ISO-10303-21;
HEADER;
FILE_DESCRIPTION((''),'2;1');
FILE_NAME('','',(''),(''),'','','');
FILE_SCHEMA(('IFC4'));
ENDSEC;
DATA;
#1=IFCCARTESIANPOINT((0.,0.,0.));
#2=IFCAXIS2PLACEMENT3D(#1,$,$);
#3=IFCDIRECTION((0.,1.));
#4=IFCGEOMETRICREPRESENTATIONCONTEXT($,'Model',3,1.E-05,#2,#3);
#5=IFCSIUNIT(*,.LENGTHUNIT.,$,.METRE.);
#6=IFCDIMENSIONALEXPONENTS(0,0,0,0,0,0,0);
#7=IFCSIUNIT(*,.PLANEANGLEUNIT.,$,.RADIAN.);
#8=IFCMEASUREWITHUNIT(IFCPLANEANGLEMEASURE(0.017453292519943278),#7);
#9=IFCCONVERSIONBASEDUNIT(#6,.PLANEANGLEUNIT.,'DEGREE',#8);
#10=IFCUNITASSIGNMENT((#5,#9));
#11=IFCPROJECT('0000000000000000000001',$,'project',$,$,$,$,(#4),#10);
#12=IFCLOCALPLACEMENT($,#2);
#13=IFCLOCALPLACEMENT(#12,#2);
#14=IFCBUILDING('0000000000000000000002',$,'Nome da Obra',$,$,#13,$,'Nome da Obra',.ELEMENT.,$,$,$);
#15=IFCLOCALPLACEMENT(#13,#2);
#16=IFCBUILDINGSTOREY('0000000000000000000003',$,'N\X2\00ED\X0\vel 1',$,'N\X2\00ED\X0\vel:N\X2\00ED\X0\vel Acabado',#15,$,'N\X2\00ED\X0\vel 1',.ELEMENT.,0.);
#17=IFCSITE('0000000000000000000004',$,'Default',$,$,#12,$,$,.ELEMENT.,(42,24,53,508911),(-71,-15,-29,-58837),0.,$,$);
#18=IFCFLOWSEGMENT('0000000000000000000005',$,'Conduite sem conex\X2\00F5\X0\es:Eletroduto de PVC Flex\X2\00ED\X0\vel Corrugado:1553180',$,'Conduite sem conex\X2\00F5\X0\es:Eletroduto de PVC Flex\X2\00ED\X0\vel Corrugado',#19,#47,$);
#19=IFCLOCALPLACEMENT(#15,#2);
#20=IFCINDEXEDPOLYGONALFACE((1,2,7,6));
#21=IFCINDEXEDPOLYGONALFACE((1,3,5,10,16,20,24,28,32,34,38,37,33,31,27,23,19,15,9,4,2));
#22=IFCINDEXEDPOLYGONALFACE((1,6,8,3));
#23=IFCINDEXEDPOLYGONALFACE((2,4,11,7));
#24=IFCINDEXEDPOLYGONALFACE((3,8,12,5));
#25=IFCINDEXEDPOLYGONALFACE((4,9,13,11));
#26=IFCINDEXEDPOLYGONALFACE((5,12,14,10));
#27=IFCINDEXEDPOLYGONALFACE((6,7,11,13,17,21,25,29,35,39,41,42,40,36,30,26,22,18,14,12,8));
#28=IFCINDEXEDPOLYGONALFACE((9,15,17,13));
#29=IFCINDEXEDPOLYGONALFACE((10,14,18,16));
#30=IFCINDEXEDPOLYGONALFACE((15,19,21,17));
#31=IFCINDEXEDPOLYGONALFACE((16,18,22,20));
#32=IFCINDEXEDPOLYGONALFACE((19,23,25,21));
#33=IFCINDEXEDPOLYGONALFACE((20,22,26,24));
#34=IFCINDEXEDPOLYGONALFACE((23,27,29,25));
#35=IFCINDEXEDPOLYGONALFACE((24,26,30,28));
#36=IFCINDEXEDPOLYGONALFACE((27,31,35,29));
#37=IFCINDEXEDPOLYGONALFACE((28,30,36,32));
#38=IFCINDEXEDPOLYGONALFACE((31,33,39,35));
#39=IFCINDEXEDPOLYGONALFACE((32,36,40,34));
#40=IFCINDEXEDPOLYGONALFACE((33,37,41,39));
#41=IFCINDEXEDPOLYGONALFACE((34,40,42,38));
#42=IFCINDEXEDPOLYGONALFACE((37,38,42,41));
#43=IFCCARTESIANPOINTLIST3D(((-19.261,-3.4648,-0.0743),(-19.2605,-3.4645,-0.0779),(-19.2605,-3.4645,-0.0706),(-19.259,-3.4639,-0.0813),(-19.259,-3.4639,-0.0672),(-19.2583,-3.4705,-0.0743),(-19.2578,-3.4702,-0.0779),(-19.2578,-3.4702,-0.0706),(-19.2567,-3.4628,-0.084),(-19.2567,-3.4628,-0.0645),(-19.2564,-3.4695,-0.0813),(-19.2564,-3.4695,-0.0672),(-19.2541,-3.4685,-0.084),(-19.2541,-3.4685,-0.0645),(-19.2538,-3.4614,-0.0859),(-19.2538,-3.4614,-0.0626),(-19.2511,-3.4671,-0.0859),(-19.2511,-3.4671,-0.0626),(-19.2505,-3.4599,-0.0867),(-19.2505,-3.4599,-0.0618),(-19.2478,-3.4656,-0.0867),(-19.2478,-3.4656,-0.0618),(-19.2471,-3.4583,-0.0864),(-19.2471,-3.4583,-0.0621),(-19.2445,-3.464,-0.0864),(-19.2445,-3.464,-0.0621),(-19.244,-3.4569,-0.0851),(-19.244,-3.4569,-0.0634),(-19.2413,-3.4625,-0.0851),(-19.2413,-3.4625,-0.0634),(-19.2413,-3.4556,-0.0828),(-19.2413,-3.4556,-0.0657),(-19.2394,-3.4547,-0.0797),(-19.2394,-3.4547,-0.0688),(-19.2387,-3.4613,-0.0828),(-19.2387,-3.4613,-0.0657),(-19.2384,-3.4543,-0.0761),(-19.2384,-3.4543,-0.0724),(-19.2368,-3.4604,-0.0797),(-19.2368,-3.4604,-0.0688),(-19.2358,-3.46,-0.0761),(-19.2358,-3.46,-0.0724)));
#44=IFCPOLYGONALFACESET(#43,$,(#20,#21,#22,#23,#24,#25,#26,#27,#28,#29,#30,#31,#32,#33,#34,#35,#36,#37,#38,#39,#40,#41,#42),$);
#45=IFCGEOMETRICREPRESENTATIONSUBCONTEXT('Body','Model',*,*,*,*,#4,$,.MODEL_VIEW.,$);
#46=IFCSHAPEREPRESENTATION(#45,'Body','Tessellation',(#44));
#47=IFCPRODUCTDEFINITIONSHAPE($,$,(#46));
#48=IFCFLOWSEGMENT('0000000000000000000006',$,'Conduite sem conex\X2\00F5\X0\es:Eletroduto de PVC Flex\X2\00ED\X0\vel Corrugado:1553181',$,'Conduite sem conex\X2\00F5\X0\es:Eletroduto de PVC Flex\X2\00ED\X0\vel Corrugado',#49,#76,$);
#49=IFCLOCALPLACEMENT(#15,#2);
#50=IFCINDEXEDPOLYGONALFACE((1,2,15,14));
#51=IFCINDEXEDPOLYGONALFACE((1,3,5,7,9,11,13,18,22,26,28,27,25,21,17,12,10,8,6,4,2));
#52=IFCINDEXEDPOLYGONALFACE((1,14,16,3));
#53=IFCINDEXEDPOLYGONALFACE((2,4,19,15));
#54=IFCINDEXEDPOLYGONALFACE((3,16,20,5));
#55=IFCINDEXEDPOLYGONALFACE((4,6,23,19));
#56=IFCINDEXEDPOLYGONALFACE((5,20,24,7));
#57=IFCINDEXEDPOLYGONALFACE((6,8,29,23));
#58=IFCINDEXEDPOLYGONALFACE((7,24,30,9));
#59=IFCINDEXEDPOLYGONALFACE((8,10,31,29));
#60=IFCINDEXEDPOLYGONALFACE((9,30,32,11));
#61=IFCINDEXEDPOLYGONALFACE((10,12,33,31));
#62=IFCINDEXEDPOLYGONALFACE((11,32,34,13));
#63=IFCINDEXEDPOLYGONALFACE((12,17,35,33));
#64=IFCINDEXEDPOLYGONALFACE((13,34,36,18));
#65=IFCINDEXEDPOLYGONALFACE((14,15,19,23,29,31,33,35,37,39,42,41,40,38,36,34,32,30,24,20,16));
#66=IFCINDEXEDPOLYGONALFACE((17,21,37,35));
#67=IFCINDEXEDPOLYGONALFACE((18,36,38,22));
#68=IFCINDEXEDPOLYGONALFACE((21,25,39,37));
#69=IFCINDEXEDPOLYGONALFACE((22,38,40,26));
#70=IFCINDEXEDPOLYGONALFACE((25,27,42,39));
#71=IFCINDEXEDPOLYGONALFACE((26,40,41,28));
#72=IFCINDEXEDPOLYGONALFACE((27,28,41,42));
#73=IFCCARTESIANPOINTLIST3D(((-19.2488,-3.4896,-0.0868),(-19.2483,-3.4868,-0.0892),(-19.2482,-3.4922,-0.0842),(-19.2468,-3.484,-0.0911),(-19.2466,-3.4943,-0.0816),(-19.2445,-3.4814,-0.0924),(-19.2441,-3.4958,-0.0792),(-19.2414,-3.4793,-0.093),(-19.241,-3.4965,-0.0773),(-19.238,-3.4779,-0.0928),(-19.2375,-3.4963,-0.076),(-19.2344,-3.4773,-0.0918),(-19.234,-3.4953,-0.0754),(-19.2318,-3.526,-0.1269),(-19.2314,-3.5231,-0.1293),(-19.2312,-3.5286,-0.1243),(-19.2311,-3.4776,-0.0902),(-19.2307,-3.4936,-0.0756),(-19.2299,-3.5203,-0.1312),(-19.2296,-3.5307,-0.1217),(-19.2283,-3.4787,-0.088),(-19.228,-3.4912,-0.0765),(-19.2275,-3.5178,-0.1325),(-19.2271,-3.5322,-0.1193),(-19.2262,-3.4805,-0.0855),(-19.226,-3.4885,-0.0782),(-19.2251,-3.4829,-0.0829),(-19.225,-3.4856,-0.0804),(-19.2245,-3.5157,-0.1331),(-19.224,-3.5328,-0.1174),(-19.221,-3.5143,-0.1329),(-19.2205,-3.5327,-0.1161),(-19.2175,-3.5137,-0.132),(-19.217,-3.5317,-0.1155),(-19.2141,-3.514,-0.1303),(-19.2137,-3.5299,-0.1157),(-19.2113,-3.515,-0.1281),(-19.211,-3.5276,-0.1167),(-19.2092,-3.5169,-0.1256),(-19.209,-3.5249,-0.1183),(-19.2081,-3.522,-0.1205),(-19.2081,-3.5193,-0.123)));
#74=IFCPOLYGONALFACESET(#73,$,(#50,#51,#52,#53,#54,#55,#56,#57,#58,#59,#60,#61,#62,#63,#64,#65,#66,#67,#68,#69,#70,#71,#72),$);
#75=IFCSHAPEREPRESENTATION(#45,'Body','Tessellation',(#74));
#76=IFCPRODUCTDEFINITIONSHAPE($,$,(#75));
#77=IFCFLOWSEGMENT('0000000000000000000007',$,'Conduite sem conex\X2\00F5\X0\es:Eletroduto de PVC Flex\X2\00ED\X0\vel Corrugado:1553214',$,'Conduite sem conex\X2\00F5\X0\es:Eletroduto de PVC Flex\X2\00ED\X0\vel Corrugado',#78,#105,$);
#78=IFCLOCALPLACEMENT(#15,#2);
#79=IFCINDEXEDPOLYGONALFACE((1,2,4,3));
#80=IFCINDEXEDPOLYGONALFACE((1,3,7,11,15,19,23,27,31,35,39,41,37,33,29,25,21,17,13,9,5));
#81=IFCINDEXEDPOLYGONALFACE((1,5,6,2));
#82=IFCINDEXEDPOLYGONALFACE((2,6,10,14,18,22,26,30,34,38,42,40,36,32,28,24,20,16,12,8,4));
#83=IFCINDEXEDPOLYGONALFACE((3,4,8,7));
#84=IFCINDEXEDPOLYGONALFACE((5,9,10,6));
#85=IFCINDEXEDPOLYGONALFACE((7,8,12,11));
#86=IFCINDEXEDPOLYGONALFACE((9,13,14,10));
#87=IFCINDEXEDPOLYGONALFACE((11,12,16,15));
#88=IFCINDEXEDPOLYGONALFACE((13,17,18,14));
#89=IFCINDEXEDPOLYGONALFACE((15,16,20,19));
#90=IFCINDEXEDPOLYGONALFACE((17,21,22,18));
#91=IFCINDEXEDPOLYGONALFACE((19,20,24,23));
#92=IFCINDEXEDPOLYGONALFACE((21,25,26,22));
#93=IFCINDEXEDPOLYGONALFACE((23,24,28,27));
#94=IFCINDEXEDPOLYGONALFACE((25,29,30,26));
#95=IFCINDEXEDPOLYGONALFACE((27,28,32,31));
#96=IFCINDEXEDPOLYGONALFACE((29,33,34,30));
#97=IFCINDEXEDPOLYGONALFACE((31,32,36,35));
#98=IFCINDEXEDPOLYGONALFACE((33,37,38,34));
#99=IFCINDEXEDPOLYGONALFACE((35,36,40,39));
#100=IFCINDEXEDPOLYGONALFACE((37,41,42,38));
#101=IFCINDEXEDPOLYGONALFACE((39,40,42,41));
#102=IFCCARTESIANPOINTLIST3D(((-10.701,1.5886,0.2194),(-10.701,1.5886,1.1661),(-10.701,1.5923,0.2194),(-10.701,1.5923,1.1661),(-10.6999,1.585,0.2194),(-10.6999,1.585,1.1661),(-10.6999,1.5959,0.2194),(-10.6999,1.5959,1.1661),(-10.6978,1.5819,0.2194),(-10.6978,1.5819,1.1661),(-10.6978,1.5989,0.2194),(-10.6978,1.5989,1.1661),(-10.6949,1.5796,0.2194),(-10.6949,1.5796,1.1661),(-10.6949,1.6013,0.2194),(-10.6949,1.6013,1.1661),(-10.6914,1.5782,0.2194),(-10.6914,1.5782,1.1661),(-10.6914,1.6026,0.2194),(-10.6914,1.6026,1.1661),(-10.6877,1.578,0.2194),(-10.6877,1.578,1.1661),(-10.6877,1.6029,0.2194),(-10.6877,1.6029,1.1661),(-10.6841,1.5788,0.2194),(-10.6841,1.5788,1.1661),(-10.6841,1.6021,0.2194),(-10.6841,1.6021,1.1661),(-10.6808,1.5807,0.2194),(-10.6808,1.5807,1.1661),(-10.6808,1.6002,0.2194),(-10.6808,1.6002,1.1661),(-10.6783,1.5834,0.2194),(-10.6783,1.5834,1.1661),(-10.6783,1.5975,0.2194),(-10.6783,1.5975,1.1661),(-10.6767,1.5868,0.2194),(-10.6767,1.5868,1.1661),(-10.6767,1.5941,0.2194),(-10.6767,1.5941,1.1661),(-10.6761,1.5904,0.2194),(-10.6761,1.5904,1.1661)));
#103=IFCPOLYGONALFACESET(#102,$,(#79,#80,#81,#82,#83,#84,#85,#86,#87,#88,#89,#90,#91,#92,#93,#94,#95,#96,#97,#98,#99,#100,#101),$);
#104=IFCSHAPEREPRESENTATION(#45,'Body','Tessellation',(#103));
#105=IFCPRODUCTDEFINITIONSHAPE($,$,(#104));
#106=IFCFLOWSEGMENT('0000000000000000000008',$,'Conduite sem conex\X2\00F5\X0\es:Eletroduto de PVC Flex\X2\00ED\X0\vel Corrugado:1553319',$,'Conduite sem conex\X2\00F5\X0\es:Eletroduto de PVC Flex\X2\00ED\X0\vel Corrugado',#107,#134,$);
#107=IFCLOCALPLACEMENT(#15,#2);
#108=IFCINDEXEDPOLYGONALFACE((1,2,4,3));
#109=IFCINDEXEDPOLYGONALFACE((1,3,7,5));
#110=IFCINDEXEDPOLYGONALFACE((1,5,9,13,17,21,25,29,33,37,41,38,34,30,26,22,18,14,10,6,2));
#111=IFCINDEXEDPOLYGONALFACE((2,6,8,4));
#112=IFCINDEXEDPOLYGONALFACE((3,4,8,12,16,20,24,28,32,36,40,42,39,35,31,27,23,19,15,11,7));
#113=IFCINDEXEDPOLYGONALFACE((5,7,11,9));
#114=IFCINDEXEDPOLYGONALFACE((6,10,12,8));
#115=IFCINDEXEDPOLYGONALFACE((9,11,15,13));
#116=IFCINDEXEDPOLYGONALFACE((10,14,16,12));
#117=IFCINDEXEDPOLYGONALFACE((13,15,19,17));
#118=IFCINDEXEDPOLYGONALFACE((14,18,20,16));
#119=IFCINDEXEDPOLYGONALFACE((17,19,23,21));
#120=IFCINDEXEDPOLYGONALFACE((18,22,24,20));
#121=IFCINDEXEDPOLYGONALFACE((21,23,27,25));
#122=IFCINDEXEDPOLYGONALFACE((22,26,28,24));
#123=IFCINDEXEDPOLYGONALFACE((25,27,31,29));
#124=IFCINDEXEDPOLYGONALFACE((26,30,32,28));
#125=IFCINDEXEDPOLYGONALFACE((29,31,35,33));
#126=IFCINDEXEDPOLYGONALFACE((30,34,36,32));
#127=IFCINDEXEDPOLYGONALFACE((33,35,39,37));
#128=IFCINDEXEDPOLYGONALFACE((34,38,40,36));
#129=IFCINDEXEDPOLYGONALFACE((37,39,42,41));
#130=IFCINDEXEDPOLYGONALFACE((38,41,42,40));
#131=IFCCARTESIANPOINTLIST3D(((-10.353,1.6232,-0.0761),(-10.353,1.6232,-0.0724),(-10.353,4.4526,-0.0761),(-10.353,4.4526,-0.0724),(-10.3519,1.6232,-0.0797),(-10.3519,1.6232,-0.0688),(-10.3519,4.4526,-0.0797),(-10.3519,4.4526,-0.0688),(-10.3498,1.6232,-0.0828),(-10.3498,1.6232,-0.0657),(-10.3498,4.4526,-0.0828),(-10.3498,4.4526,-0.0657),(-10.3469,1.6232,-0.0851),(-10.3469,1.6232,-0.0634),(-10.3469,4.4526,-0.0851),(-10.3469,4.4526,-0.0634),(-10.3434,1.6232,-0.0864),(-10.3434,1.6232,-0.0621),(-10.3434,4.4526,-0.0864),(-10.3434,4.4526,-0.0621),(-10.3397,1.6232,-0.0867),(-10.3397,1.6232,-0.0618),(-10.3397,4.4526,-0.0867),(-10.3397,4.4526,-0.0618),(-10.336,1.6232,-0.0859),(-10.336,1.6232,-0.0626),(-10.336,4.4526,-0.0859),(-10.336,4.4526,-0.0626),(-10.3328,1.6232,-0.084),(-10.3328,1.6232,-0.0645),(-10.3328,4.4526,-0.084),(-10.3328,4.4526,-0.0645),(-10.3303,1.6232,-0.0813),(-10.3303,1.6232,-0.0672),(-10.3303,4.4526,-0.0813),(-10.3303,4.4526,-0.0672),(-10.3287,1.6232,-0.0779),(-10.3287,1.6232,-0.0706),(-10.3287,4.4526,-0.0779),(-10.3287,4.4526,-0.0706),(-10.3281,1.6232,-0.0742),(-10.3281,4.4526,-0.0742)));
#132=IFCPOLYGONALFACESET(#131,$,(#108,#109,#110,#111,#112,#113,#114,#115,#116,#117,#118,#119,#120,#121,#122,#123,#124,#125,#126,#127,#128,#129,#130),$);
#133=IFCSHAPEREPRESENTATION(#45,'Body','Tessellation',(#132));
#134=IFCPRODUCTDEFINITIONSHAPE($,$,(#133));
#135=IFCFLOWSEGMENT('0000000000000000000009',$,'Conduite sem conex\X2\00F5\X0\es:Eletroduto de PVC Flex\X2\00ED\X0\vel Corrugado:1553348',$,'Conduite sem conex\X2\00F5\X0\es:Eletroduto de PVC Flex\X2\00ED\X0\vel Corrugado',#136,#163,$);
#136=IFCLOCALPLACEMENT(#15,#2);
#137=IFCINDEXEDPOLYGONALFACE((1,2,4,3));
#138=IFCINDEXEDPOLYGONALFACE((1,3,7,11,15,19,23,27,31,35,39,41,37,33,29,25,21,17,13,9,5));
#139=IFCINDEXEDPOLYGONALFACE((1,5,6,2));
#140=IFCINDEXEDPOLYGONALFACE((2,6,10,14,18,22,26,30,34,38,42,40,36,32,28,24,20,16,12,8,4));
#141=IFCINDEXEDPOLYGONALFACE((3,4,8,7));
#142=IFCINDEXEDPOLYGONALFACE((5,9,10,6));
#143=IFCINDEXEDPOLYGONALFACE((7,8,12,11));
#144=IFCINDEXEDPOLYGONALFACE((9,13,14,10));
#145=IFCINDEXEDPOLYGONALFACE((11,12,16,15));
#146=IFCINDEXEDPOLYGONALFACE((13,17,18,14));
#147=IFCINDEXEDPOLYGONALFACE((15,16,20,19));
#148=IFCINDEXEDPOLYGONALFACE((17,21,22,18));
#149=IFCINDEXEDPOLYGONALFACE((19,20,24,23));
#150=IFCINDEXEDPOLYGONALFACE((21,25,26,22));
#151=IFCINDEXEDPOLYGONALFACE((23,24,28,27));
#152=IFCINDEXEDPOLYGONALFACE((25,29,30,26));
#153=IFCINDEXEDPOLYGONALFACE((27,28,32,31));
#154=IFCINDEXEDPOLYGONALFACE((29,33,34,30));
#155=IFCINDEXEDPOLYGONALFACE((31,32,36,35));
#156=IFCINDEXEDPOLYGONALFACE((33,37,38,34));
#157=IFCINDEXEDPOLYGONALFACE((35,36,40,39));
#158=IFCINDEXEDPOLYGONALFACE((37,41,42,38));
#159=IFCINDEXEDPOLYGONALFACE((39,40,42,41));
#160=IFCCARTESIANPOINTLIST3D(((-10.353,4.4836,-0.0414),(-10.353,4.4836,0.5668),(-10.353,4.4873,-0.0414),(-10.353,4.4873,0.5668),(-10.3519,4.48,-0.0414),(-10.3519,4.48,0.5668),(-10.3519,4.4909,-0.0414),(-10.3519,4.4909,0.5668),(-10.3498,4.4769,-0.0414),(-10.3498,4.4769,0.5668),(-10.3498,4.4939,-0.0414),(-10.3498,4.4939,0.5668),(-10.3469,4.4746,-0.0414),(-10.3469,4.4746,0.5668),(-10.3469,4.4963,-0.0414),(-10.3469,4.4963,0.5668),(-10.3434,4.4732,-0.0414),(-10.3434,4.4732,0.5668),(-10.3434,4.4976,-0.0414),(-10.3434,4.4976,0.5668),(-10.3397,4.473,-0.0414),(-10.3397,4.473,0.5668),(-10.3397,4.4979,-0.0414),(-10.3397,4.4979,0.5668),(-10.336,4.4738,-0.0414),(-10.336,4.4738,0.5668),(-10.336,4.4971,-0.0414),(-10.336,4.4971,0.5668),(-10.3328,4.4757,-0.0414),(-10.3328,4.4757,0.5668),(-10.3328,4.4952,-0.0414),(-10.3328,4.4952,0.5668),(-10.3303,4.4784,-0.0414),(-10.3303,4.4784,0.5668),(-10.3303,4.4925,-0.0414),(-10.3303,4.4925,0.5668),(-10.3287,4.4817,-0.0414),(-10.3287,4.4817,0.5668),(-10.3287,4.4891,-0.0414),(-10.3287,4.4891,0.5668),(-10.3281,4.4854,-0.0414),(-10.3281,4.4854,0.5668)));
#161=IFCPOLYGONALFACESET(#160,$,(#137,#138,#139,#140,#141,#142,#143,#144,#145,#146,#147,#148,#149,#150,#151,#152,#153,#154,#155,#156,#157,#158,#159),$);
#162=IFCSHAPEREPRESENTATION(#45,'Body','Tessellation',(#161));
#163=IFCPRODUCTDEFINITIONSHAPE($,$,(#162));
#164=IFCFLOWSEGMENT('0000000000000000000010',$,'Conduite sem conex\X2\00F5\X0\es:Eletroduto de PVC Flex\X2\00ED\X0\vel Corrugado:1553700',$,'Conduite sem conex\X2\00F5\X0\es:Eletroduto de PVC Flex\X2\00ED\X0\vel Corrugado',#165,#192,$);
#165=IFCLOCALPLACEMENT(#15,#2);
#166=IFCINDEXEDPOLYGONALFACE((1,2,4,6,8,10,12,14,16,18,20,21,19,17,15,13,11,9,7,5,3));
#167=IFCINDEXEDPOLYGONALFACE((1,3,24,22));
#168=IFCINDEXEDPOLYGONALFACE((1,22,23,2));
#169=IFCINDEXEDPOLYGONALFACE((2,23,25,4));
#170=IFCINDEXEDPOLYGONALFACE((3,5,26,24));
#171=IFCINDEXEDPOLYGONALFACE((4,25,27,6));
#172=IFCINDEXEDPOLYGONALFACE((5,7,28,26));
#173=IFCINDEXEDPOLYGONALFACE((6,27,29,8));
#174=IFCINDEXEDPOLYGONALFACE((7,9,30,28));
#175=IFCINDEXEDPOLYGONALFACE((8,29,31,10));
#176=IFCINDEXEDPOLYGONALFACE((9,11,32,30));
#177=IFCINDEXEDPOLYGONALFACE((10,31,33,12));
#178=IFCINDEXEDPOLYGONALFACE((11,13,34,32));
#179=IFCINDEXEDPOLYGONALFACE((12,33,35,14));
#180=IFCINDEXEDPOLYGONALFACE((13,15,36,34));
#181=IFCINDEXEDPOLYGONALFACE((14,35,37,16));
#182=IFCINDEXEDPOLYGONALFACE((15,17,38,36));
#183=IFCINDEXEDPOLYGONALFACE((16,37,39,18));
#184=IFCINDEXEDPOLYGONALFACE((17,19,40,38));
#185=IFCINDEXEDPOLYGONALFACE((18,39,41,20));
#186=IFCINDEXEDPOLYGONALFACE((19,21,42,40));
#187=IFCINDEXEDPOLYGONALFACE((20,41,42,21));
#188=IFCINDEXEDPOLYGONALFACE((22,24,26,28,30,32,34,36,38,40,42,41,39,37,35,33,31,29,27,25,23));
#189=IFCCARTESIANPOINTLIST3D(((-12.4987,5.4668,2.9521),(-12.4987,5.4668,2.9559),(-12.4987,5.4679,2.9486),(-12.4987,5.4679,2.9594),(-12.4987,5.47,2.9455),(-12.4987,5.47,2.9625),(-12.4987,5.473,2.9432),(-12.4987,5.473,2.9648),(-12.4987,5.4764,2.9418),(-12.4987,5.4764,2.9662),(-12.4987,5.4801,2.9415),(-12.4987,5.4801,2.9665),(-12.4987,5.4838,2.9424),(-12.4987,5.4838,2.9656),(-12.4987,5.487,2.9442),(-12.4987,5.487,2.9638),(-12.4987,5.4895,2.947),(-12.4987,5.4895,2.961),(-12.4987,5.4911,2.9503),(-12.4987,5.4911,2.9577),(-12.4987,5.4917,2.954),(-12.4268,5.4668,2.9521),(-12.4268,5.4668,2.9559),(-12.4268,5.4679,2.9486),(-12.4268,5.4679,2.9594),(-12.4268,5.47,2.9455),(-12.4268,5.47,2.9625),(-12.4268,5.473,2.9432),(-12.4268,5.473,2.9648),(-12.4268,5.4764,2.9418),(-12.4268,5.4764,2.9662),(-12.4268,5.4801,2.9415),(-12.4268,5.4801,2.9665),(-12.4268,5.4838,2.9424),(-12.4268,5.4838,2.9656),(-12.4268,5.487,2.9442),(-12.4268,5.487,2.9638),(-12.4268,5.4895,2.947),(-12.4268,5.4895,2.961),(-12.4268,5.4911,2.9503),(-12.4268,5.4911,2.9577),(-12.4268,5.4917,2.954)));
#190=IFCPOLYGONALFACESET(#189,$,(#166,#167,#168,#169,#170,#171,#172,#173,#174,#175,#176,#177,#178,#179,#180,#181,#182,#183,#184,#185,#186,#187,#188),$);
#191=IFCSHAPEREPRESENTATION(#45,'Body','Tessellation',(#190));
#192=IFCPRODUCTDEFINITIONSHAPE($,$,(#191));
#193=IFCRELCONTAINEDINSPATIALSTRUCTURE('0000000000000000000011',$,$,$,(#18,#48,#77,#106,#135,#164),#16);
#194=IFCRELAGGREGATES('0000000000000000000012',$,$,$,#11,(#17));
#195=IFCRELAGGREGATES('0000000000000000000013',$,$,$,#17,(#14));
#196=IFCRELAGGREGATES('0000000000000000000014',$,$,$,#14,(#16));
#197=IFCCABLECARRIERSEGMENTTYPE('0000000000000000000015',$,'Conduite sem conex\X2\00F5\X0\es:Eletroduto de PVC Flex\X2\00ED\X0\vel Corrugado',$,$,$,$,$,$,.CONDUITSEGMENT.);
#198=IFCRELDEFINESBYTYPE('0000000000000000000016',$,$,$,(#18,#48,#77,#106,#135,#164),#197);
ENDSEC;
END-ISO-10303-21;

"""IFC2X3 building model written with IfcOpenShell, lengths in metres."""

from ifc_helpers import new_model, entity, si_unit, converted_unit, direction, frame, frame_2d, origin, origin_2d_with_axis, place, context, subcontext, project, spatial, circle, extrude, type_object, element, save


model = new_model("IFC2X3")

# Units and contexts
model_context = context("Model", 3, precision=1e-05, world=origin(), true_north=direction((0.0, 1.0)))
body_context = subcontext(model_context, "Body", "Model", "MODEL_VIEW")
ifc_project = project(units=[si_unit("LENGTHUNIT", "METRE"), converted_unit("PLANEANGLEUNIT", "DEGREE", entity("IfcPlaneAngleMeasure", 0.017453292519943278), si_unit("PLANEANGLEUNIT", "RADIAN"), dimensions=[0, 0, 0, 0, 0, 0, 0])], contexts=[model_context])

# Site, building, storey
site_placement = place(None, origin())
site = spatial("IfcSite", under=ifc_project, at=site_placement, Name="Default", CompositionType="ELEMENT", RefLatitude=(42, 24, 53, 508911), RefLongitude=(-71, -15, -29, -58837), RefElevation=0.0)
building_placement = place(site_placement, origin())
building = spatial("IfcBuilding", under=site, at=building_placement, Name="Nome da Obra", LongName="Nome da Obra", CompositionType="ELEMENT")
storey_placement = place(building_placement, origin())
storey = spatial("IfcBuildingStorey", under=building, at=storey_placement, Name="Nível 1", ObjectType="Nível:Nível Acabado", LongName="Nível 1", CompositionType="ELEMENT", Elevation=0.0)

# Flow segments
cable_carrier_segment_type = type_object("IfcCableCarrierSegmentType", Name="Conduite sem conexões:Eletroduto de PVC Flexível Corrugado", PredefinedType="CONDUITSEGMENT")
flow_segment_1_placement = place(storey_placement, origin())
element("IfcFlowSegment", 1, at=flow_segment_1_placement, inside=storey, type_object=cable_carrier_segment_type, Name="Conduite sem conexões:Eletroduto de PVC Flexível Corrugado:1553180", ObjectType="Conduite sem conexões:Eletroduto de PVC Flexível Corrugado", context=body_context, shape_type="SweptSolid", body=[
    extrude(circle(Radius=0.0125, at=frame_2d((0.0, 0.0), x_axis=(1.0, 0.0))), frame((-19.2496, -3.4595, -0.0743), z_axis=(0.422752, -0.906246, 0.0), x_axis=(-0.906246, -0.422752, 0.0)), (0.0, 0.0, 1.0), 0.0063),
])
flow_segment_2_placement = place(storey_placement, origin())
element("IfcFlowSegment", 2, at=flow_segment_2_placement, inside=storey, type_object=cable_carrier_segment_type, Name="Conduite sem conexões:Eletroduto de PVC Flexível Corrugado:1553181", ObjectType="Conduite sem conexões:Eletroduto de PVC Flexível Corrugado", context=body_context, shape_type="SweptSolid", body=[
    extrude(circle(Radius=0.0125, at=frame_2d((0.0, 0.0), x_axis=(1.0, 0.0))), frame((-19.2199, -3.5233, -0.1243), z_axis=(-0.29893, 0.640812, 0.707107), x_axis=(-0.906246, -0.422752, 0.0)), (0.0, 0.0, 1.0), 0.0567),
])
flow_segment_3_placement = place(storey_placement, origin())
element("IfcFlowSegment", 3, at=flow_segment_3_placement, inside=storey, type_object=cable_carrier_segment_type, Name="Conduite sem conexões:Eletroduto de PVC Flexível Corrugado:1553214", ObjectType="Conduite sem conexões:Eletroduto de PVC Flexível Corrugado", context=body_context, shape_type="SweptSolid", body=[
    extrude(circle(Radius=0.0125, at=origin_2d_with_axis()), frame((-10.6886, 1.5904, 0.2194)), (0.0, 0.0, 1.0), 0.9467),
])
flow_segment_4_placement = place(storey_placement, origin())
element("IfcFlowSegment", 4, at=flow_segment_4_placement, inside=storey, type_object=cable_carrier_segment_type, Name="Conduite sem conexões:Eletroduto de PVC Flexível Corrugado:1553319", ObjectType="Conduite sem conexões:Eletroduto de PVC Flexível Corrugado", context=body_context, shape_type="SweptSolid", body=[
    extrude(circle(Radius=0.0125, at=frame_2d((0.0, 0.0), x_axis=(1.0, 0.0))), frame((-10.3406, 1.6232, -0.0742), z_axis=(0.0, 1.0, 0.0), x_axis=(1.0, 0.0, 0.0)), (0.0, 0.0, 1.0), 2.8294),
])
flow_segment_5_placement = place(storey_placement, origin())
element("IfcFlowSegment", 5, at=flow_segment_5_placement, inside=storey, type_object=cable_carrier_segment_type, Name="Conduite sem conexões:Eletroduto de PVC Flexível Corrugado:1553348", ObjectType="Conduite sem conexões:Eletroduto de PVC Flexível Corrugado", context=body_context, shape_type="SweptSolid", body=[
    extrude(circle(Radius=0.0125, at=origin_2d_with_axis()), frame((-10.3406, 4.4854, -0.0414)), (0.0, 0.0, 1.0), 0.6082),
])
flow_segment_6_placement = place(storey_placement, origin())
element("IfcFlowSegment", 6, at=flow_segment_6_placement, inside=storey, type_object=cable_carrier_segment_type, Name="Conduite sem conexões:Eletroduto de PVC Flexível Corrugado:1553700", ObjectType="Conduite sem conexões:Eletroduto de PVC Flexível Corrugado", context=body_context, shape_type="SweptSolid", body=[
    extrude(circle(Radius=0.0125, at=origin_2d_with_axis()), frame((-12.4987, 5.4792, 2.954), z_axis=(1.0, 0.0, 0.0), x_axis=(0.0, 1.0, 0.0)), (0.0, 0.0, 1.0), 0.0719),
])

save(model, "model.ifc")
